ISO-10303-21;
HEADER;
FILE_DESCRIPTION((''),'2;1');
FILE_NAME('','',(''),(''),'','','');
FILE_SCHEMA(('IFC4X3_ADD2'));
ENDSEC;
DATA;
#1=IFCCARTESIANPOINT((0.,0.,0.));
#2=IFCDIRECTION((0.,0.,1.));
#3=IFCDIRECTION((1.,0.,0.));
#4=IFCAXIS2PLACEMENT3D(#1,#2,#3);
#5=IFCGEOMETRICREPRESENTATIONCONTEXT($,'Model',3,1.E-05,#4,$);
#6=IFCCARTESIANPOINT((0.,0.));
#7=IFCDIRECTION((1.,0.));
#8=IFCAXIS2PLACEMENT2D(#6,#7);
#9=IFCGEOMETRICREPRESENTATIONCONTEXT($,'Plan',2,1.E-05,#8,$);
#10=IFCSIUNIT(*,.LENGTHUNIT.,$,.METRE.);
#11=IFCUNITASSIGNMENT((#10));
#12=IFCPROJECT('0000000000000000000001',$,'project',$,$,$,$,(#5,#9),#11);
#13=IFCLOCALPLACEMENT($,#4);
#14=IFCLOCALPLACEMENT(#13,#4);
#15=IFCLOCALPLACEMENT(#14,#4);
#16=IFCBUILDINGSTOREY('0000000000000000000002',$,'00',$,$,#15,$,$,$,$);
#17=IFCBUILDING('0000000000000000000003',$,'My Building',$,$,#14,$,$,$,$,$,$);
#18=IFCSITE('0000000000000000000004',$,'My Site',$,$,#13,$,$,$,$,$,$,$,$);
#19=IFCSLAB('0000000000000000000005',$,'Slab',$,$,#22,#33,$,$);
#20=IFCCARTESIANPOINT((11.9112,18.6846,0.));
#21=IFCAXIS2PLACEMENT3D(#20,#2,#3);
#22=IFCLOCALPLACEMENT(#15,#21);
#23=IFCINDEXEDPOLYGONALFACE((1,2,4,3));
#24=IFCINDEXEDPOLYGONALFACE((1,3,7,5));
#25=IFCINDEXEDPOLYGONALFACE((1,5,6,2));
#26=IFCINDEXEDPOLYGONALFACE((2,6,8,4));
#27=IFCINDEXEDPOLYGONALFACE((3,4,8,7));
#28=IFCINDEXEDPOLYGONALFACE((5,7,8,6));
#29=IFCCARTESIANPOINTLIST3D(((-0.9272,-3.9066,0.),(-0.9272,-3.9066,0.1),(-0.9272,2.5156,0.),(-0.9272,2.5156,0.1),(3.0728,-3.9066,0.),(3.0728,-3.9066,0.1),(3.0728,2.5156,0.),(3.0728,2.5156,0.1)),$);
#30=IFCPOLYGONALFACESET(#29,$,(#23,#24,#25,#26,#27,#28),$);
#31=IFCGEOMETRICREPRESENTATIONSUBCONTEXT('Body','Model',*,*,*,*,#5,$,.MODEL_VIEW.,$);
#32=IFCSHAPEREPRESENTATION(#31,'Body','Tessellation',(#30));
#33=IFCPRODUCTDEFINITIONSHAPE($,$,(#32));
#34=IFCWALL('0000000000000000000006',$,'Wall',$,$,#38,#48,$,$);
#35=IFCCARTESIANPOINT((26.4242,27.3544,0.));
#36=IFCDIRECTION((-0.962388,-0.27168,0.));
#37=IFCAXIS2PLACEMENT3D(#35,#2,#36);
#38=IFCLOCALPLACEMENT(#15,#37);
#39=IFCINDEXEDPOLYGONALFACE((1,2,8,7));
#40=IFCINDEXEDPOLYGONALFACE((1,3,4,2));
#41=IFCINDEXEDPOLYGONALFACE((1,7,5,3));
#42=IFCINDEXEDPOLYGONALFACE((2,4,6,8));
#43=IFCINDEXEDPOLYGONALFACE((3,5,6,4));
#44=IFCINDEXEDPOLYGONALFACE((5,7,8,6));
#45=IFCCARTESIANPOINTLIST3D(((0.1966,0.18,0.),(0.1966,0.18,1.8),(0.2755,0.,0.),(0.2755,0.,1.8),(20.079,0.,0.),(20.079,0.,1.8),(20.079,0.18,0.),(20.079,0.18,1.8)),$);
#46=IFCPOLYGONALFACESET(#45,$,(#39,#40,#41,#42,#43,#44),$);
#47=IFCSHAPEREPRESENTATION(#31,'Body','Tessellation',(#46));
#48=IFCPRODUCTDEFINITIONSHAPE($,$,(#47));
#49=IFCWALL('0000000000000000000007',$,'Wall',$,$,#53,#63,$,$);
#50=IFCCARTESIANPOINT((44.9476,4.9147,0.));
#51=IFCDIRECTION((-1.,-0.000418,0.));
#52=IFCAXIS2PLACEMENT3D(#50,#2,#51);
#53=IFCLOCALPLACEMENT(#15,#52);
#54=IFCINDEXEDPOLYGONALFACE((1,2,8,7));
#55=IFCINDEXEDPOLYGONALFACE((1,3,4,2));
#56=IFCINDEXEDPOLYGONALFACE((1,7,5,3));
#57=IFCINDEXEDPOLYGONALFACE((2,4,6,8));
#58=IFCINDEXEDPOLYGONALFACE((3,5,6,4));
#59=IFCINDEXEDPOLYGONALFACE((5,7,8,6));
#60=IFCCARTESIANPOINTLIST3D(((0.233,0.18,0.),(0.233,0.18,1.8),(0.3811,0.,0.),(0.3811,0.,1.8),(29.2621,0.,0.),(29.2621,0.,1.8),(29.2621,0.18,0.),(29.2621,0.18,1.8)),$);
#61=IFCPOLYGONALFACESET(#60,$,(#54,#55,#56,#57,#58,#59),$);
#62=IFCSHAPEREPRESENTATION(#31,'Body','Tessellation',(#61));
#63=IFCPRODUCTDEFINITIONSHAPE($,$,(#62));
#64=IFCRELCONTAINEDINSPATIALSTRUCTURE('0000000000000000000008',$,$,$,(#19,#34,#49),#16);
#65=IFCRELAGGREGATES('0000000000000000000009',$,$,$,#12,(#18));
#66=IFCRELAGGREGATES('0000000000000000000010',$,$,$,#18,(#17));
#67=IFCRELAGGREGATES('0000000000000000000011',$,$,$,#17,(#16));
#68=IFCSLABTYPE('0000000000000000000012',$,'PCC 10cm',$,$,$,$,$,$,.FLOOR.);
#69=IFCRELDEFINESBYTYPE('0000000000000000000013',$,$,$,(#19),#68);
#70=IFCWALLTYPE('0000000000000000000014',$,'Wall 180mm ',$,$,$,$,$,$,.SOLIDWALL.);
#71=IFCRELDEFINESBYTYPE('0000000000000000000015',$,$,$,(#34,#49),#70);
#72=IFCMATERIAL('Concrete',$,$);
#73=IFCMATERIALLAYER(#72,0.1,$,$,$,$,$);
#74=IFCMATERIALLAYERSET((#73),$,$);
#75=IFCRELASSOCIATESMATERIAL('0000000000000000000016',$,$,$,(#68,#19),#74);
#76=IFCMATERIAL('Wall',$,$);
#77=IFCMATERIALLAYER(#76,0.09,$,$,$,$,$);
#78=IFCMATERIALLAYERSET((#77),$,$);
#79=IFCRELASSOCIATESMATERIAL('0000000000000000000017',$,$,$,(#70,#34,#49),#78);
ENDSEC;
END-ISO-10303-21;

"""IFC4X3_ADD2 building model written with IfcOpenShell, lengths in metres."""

from ifc_helpers import new_model, si_unit, frame, origin_with_axes, origin_2d_with_axis, place, context, subcontext, project, spatial, line, indexed_curve, outline, extrude, clip, halfspace, material, layer, layer_set, layer_usage, type_object, element, save


model = new_model("IFC4X3_ADD2")

# Units and contexts
model_context = context("Model", 3, precision=1e-05, world=origin_with_axes())
plan_context = context("Plan", 2, precision=1e-05, world=origin_2d_with_axis())
body_context_1 = subcontext(model_context, "Body", "Model", "MODEL_VIEW")
ifc_project = project(units=[si_unit("LENGTHUNIT", "METRE")], contexts=[model_context, plan_context])

# Site, building, storey
site_placement = place(None, origin_with_axes())
site = spatial("IfcSite", under=ifc_project, at=site_placement, Name="My Site")
building_placement = place(site_placement, origin_with_axes())
building = spatial("IfcBuilding", under=site, at=building_placement, Name="My Building")
storey_placement = place(building_placement, origin_with_axes())
storey = spatial("IfcBuildingStorey", under=building, at=storey_placement, Name="00")

# Slab
ifc_material_1 = material(Name="Concrete")
ifc_layer_1 = layer(ifc_material_1, 0.1)
ifc_layer_set_1 = layer_set([ifc_layer_1])
ifc_layer_usage_1 = layer_usage(ifc_layer_set_1, "AXIS3", "POSITIVE", 0.0)
slab_type = type_object("IfcSlabType", Name="PCC 10cm", PredefinedType="FLOOR", material=ifc_layer_set_1)
slab_placement = place(storey_placement, frame((11.9112, 18.6846, 0.0), z_axis=(0.0, 0.0, 1.0), x_axis=(1.0, 0.0, 0.0)))
element("IfcSlab", 1, at=slab_placement, inside=storey, type_object=slab_type, material=ifc_layer_usage_1, Name="Slab", context=body_context_1, shape_type="SweptSolid", body=[
    extrude(outline(indexed_curve([(3.0728, 2.5156), (3.0728, -3.9066), (-0.9272, -3.9066), (-0.9272, 2.5156)], segments=[line(3, 2), line(2, 1), line(1, 4), line(4, 3)], self_intersect=False)), None, (0.0, 0.0, 1.0), 0.1),
])

# Walls
ifc_material_2 = material(Name="Wall")
ifc_layer_2 = layer(ifc_material_2, 0.09)
ifc_layer_set_2 = layer_set([ifc_layer_2])
ifc_layer_usage_2 = layer_usage(ifc_layer_set_2, "AXIS2", "POSITIVE", 0.0)
wall_type_1 = type_object("IfcWallType", Name="Wall 180mm ", PredefinedType="SOLIDWALL", material=ifc_layer_set_2)
wall_1_placement = place(storey_placement, frame((26.4242, 27.3544, 0.0), z_axis=(0.0, 0.0, 1.0), x_axis=(-0.962388, -0.27168, 0.0)))
element("IfcWall", 2, at=wall_1_placement, inside=storey, type_object=wall_type_1, material=ifc_layer_usage_2, Name="Wall", context=body_context_1, shape_type="Clipping", body=[
    clip(extrude(outline(indexed_curve([(0.0, 0.0), (0.0, 0.18), (20.079, 0.18), (20.079, 0.0), (0.0, 0.0)], self_intersect=False)), origin_with_axes(), (0.0, 0.0, 1.0), 1.8), halfspace(frame((0.2755, 0.0, 0.0), z_axis=(-0.323993, -0.14217, 0.0), x_axis=(-0.401823, 0.915717, 0.0)), False)),
])
ifc_layer_usage_3 = layer_usage(ifc_layer_set_2, "AXIS2", "POSITIVE", 0.0)
wall_2_placement = place(storey_placement, frame((44.9476, 4.9147, 0.0), z_axis=(0.0, 0.0, 1.0), x_axis=(-1.0, -0.000418, 0.0)))
element("IfcWall", 3, at=wall_2_placement, inside=storey, type_object=wall_type_1, material=ifc_layer_usage_3, Name="Wall", context=body_context_1, shape_type="Clipping", body=[
    clip(extrude(outline(indexed_curve([(0.0, 0.0), (0.0, 0.18), (29.2621, 0.18), (29.2621, 0.0), (0.0, 0.0)], self_intersect=False)), origin_with_axes(), (0.0, 0.0, 1.0), 1.8), halfspace(frame((0.3811, 0.0, 0.0), z_axis=(-0.539999, -0.44408, 0.0), x_axis=(-0.635174, 0.772369, 0.0)), False)),
])

save(model, "model.ifc")
